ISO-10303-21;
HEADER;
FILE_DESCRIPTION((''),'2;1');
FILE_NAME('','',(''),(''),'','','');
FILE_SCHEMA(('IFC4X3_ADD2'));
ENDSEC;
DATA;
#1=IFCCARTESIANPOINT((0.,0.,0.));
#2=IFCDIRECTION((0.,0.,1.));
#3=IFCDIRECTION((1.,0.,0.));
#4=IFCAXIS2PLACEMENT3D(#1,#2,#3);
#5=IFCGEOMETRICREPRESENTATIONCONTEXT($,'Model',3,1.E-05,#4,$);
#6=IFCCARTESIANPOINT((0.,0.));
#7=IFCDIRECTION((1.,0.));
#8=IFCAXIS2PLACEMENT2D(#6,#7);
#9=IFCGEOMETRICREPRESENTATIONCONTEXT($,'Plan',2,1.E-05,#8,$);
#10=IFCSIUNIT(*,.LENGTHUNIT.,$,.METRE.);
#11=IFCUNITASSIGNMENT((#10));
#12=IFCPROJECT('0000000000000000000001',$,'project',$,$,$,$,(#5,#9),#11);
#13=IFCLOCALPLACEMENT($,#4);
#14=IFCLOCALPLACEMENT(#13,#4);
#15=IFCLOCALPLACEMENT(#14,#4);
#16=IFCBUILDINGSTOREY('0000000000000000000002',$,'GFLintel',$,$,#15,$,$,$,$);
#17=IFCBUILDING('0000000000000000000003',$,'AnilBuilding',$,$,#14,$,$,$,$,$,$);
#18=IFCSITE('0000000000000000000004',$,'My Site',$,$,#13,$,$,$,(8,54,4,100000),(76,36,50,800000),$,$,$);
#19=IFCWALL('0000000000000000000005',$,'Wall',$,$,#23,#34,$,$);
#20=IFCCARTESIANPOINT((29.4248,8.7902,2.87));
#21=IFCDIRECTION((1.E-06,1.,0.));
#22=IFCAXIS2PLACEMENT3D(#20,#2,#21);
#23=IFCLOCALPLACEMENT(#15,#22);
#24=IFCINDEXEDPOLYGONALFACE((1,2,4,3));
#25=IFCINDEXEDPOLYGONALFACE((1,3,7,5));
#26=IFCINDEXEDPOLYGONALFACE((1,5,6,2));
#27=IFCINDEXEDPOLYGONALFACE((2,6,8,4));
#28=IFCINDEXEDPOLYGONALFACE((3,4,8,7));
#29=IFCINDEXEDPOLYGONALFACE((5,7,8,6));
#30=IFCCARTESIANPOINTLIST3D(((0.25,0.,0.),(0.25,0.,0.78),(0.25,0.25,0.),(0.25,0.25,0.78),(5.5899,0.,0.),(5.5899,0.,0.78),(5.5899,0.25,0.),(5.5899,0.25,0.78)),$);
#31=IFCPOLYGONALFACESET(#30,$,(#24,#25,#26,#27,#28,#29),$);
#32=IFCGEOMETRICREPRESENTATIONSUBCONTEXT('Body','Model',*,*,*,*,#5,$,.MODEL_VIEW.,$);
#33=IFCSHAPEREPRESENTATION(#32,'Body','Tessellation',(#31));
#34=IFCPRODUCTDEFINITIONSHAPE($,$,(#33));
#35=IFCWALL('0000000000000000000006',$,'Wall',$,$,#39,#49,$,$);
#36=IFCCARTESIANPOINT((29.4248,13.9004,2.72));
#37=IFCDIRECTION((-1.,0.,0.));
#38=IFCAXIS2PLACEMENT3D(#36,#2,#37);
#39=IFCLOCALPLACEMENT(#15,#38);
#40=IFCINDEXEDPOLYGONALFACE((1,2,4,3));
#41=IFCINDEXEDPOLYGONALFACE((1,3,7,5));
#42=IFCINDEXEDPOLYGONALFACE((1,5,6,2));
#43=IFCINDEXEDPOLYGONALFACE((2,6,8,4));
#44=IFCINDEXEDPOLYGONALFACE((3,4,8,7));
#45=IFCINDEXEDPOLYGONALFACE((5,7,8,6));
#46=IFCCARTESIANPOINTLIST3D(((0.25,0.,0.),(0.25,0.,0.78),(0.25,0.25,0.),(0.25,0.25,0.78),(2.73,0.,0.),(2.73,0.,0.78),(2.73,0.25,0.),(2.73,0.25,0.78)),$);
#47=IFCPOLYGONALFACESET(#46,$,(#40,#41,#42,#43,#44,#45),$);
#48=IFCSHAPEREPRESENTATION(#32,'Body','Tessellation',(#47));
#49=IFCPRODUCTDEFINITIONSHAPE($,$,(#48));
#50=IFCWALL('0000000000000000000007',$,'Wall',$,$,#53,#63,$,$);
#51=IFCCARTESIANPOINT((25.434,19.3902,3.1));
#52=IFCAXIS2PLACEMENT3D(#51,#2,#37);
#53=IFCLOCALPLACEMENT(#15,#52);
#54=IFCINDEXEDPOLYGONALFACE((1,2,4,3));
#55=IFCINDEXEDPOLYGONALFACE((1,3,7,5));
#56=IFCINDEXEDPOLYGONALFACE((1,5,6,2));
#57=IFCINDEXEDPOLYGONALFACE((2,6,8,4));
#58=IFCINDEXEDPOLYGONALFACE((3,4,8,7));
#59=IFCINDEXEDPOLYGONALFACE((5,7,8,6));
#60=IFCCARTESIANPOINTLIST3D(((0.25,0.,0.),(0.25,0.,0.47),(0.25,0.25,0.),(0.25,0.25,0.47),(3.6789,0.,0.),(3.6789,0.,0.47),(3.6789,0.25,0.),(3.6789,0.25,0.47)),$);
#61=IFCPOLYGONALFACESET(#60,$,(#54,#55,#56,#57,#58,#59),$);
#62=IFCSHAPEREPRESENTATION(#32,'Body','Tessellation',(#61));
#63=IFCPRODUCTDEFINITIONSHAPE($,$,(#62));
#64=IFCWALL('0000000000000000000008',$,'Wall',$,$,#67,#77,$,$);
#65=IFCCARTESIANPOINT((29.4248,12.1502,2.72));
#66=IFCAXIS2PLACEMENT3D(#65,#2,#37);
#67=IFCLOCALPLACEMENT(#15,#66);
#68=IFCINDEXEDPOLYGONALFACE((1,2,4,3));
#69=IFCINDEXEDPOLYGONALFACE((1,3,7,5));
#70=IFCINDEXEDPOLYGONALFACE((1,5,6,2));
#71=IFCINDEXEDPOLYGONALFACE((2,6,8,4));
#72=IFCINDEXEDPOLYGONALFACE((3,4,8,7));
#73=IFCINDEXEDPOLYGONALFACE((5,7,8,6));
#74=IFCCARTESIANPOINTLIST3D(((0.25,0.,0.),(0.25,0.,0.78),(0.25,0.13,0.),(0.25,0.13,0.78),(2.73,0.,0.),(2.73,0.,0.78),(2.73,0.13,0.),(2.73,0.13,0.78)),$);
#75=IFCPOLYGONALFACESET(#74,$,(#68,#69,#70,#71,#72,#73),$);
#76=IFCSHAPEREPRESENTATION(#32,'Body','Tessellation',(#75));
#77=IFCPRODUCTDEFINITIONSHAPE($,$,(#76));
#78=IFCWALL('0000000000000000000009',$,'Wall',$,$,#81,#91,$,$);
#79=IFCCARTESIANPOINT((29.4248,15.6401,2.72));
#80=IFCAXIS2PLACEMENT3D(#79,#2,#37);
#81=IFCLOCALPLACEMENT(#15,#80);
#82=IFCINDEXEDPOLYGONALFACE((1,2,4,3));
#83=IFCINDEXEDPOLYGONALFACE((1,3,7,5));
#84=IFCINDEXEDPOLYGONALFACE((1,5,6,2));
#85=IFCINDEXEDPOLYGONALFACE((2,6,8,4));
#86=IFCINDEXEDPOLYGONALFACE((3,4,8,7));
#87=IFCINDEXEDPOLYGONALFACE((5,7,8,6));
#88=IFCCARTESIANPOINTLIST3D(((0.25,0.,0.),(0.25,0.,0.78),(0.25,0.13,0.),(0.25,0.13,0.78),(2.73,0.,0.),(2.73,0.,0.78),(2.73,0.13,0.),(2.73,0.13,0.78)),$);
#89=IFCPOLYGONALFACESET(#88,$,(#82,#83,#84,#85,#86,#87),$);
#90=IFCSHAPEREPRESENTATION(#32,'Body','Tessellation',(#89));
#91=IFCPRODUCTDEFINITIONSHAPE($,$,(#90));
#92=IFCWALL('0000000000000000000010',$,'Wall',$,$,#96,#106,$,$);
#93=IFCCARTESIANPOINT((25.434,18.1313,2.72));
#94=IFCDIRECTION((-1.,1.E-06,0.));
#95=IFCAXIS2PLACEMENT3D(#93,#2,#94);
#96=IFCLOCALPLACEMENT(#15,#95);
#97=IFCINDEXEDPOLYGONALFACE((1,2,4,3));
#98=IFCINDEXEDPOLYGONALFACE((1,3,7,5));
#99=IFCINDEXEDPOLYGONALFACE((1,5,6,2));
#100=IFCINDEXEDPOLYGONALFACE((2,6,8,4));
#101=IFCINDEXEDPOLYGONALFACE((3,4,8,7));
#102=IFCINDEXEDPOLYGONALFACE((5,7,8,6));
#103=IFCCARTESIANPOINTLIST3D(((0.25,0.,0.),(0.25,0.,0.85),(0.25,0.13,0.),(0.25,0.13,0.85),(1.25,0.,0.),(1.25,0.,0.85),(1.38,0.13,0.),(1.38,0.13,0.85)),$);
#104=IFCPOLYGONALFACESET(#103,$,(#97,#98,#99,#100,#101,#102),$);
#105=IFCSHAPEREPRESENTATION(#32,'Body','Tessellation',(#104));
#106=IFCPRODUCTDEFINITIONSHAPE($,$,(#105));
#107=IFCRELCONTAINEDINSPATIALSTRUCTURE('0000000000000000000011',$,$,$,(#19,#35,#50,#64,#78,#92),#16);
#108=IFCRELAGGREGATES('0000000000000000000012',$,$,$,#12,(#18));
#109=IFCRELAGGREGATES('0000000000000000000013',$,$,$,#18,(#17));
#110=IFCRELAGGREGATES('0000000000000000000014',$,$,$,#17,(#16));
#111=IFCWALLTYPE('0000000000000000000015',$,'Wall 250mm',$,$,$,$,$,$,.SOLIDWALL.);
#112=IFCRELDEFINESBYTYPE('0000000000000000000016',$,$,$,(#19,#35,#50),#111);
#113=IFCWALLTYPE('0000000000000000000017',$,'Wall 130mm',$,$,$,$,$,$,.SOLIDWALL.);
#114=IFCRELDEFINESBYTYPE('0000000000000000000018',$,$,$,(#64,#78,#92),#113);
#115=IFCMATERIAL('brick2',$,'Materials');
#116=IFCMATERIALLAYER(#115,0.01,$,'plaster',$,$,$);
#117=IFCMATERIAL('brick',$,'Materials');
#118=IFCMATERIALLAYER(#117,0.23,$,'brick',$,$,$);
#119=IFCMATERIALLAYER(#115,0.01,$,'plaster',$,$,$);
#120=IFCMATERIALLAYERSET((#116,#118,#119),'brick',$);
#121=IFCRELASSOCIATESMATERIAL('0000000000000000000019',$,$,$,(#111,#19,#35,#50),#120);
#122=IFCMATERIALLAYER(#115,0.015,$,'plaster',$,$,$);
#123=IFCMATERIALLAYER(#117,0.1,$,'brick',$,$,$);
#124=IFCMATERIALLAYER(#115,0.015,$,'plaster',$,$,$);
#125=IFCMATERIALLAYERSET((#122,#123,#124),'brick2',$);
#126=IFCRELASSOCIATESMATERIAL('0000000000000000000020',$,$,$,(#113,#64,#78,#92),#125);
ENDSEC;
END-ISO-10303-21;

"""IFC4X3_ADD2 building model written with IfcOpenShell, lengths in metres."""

from ifc_helpers import new_model, si_unit, frame, origin_with_axes, origin_2d_with_axis, place, context, subcontext, project, spatial, line, indexed_curve, outline, extrude, material, layer, layer_set, layer_usage, type_object, element, save


model = new_model("IFC4X3_ADD2")

# Units and contexts
model_context = context("Model", 3, precision=1e-05, world=origin_with_axes())
plan_context = context("Plan", 2, precision=1e-05, world=origin_2d_with_axis())
body_context = subcontext(model_context, "Body", "Model", "MODEL_VIEW")
ifc_project = project(units=[si_unit("LENGTHUNIT", "METRE")], contexts=[model_context, plan_context])

# Site, building, storey
site_placement = place(None, origin_with_axes())
site = spatial("IfcSite", under=ifc_project, at=site_placement, Name="My Site", RefLatitude=(8, 54, 4, 100000), RefLongitude=(76, 36, 50, 800000))
building_placement = place(site_placement, origin_with_axes())
building = spatial("IfcBuilding", under=site, at=building_placement, Name="AnilBuilding")
storey_placement = place(building_placement, origin_with_axes())
storey = spatial("IfcBuildingStorey", under=building, at=storey_placement, Name="GFLintel")

# Walls
ifc_material_1 = material(Name="brick2", Category="Materials")
ifc_layer_1 = layer(ifc_material_1, 0.01, Name="plaster")
ifc_material_2 = material(Name="brick", Category="Materials")
ifc_layer_2 = layer(ifc_material_2, 0.23, Name="brick")
ifc_layer_3 = layer(ifc_material_1, 0.01, Name="plaster")
ifc_layer_set_1 = layer_set([ifc_layer_1, ifc_layer_2, ifc_layer_3], Name="brick")
wall_type_1 = type_object("IfcWallType", Name="Wall 250mm", PredefinedType="SOLIDWALL", material=ifc_layer_set_1)
ifc_layer_usage_1 = layer_usage(ifc_layer_set_1, "AXIS2", "POSITIVE", 0.0)
wall_1_placement = place(storey_placement, frame((29.4248, 8.7902, 2.87), z_axis=(0.0, 0.0, 1.0), x_axis=(0.000001, 1.0, 0.0)))
element("IfcWall", 1, at=wall_1_placement, inside=storey, type_object=wall_type_1, material=ifc_layer_usage_1, Name="Wall", context=body_context, shape_type="SweptSolid", body=[
    extrude(outline(indexed_curve([(0.25, 0.0), (0.25, 0.25), (5.5899, 0.25), (5.5899, 0.0)], segments=[line(1, 2, 3, 4, 1)])), origin_with_axes(), (0.0, 0.0, 1.0), 0.78),
])
ifc_layer_usage_2 = layer_usage(ifc_layer_set_1, "AXIS2", "POSITIVE", 0.0)
wall_2_placement = place(storey_placement, frame((29.4248, 13.9004, 2.72), z_axis=(0.0, 0.0, 1.0), x_axis=(-1.0, 0.0, 0.0)))
element("IfcWall", 2, at=wall_2_placement, inside=storey, type_object=wall_type_1, material=ifc_layer_usage_2, Name="Wall", context=body_context, shape_type="SweptSolid", body=[
    extrude(outline(indexed_curve([(0.25, 0.0), (0.25, 0.25), (2.73, 0.25), (2.73, 0.0)], segments=[line(1, 2, 3, 4, 1)])), origin_with_axes(), (0.0, 0.0, 1.0), 0.78),
])
ifc_layer_usage_3 = layer_usage(ifc_layer_set_1, "AXIS2", "POSITIVE", 0.0)
wall_3_placement = place(storey_placement, frame((25.434, 19.3902, 3.1), z_axis=(0.0, 0.0, 1.0), x_axis=(-1.0, 0.0, 0.0)))
element("IfcWall", 3, at=wall_3_placement, inside=storey, type_object=wall_type_1, material=ifc_layer_usage_3, Name="Wall", context=body_context, shape_type="SweptSolid", body=[
    extrude(outline(indexed_curve([(0.25, 0.0), (0.25, 0.25), (3.6789, 0.25), (3.6789, 0.0)], segments=[line(1, 2, 3, 4, 1)])), origin_with_axes(), (0.0, 0.0, 1.0), 0.47),
])
ifc_layer_4 = layer(ifc_material_1, 0.015, Name="plaster")
ifc_layer_5 = layer(ifc_material_2, 0.1, Name="brick")
ifc_layer_6 = layer(ifc_material_1, 0.015, Name="plaster")
ifc_layer_set_2 = layer_set([ifc_layer_4, ifc_layer_5, ifc_layer_6], Name="brick2")
ifc_layer_usage_4 = layer_usage(ifc_layer_set_2, "AXIS2", "POSITIVE", 0.0)
wall_type_2 = type_object("IfcWallType", Name="Wall 130mm", PredefinedType="SOLIDWALL", material=ifc_layer_set_2)
wall_4_placement = place(storey_placement, frame((29.4248, 12.1502, 2.72), z_axis=(0.0, 0.0, 1.0), x_axis=(-1.0, 0.0, 0.0)))
element("IfcWall", 4, at=wall_4_placement, inside=storey, type_object=wall_type_2, material=ifc_layer_usage_4, Name="Wall", context=body_context, shape_type="SweptSolid", body=[
    extrude(outline(indexed_curve([(0.25, 0.0), (0.25, 0.13), (2.73, 0.13), (2.73, 0.0)], segments=[line(1, 2, 3, 4, 1)])), origin_with_axes(), (0.0, 0.0, 1.0), 0.78),
])
ifc_layer_usage_5 = layer_usage(ifc_layer_set_2, "AXIS2", "POSITIVE", 0.0)
wall_5_placement = place(storey_placement, frame((29.4248, 15.6401, 2.72), z_axis=(0.0, 0.0, 1.0), x_axis=(-1.0, 0.0, 0.0)))
element("IfcWall", 5, at=wall_5_placement, inside=storey, type_object=wall_type_2, material=ifc_layer_usage_5, Name="Wall", context=body_context, shape_type="SweptSolid", body=[
    extrude(outline(indexed_curve([(0.25, 0.0), (0.25, 0.13), (2.73, 0.13), (2.73, 0.0)], segments=[line(1, 2, 3, 4, 1)])), origin_with_axes(), (0.0, 0.0, 1.0), 0.78),
])
ifc_layer_usage_6 = layer_usage(ifc_layer_set_2, "AXIS2", "POSITIVE", 0.0)
wall_6_placement = place(storey_placement, frame((25.434, 18.1313, 2.72), z_axis=(0.0, 0.0, 1.0), x_axis=(-1.0, 0.000001, 0.0)))
element("IfcWall", 6, at=wall_6_placement, inside=storey, type_object=wall_type_2, material=ifc_layer_usage_6, Name="Wall", context=body_context, shape_type="SweptSolid", body=[
    extrude(outline(indexed_curve([(0.25, 0.0), (0.25, 0.13), (1.38, 0.13), (1.25, 0.0)], segments=[line(1, 2, 3, 4, 1)])), origin_with_axes(), (0.0, 0.0, 1.0), 0.85),
])

save(model, "model.ifc")
